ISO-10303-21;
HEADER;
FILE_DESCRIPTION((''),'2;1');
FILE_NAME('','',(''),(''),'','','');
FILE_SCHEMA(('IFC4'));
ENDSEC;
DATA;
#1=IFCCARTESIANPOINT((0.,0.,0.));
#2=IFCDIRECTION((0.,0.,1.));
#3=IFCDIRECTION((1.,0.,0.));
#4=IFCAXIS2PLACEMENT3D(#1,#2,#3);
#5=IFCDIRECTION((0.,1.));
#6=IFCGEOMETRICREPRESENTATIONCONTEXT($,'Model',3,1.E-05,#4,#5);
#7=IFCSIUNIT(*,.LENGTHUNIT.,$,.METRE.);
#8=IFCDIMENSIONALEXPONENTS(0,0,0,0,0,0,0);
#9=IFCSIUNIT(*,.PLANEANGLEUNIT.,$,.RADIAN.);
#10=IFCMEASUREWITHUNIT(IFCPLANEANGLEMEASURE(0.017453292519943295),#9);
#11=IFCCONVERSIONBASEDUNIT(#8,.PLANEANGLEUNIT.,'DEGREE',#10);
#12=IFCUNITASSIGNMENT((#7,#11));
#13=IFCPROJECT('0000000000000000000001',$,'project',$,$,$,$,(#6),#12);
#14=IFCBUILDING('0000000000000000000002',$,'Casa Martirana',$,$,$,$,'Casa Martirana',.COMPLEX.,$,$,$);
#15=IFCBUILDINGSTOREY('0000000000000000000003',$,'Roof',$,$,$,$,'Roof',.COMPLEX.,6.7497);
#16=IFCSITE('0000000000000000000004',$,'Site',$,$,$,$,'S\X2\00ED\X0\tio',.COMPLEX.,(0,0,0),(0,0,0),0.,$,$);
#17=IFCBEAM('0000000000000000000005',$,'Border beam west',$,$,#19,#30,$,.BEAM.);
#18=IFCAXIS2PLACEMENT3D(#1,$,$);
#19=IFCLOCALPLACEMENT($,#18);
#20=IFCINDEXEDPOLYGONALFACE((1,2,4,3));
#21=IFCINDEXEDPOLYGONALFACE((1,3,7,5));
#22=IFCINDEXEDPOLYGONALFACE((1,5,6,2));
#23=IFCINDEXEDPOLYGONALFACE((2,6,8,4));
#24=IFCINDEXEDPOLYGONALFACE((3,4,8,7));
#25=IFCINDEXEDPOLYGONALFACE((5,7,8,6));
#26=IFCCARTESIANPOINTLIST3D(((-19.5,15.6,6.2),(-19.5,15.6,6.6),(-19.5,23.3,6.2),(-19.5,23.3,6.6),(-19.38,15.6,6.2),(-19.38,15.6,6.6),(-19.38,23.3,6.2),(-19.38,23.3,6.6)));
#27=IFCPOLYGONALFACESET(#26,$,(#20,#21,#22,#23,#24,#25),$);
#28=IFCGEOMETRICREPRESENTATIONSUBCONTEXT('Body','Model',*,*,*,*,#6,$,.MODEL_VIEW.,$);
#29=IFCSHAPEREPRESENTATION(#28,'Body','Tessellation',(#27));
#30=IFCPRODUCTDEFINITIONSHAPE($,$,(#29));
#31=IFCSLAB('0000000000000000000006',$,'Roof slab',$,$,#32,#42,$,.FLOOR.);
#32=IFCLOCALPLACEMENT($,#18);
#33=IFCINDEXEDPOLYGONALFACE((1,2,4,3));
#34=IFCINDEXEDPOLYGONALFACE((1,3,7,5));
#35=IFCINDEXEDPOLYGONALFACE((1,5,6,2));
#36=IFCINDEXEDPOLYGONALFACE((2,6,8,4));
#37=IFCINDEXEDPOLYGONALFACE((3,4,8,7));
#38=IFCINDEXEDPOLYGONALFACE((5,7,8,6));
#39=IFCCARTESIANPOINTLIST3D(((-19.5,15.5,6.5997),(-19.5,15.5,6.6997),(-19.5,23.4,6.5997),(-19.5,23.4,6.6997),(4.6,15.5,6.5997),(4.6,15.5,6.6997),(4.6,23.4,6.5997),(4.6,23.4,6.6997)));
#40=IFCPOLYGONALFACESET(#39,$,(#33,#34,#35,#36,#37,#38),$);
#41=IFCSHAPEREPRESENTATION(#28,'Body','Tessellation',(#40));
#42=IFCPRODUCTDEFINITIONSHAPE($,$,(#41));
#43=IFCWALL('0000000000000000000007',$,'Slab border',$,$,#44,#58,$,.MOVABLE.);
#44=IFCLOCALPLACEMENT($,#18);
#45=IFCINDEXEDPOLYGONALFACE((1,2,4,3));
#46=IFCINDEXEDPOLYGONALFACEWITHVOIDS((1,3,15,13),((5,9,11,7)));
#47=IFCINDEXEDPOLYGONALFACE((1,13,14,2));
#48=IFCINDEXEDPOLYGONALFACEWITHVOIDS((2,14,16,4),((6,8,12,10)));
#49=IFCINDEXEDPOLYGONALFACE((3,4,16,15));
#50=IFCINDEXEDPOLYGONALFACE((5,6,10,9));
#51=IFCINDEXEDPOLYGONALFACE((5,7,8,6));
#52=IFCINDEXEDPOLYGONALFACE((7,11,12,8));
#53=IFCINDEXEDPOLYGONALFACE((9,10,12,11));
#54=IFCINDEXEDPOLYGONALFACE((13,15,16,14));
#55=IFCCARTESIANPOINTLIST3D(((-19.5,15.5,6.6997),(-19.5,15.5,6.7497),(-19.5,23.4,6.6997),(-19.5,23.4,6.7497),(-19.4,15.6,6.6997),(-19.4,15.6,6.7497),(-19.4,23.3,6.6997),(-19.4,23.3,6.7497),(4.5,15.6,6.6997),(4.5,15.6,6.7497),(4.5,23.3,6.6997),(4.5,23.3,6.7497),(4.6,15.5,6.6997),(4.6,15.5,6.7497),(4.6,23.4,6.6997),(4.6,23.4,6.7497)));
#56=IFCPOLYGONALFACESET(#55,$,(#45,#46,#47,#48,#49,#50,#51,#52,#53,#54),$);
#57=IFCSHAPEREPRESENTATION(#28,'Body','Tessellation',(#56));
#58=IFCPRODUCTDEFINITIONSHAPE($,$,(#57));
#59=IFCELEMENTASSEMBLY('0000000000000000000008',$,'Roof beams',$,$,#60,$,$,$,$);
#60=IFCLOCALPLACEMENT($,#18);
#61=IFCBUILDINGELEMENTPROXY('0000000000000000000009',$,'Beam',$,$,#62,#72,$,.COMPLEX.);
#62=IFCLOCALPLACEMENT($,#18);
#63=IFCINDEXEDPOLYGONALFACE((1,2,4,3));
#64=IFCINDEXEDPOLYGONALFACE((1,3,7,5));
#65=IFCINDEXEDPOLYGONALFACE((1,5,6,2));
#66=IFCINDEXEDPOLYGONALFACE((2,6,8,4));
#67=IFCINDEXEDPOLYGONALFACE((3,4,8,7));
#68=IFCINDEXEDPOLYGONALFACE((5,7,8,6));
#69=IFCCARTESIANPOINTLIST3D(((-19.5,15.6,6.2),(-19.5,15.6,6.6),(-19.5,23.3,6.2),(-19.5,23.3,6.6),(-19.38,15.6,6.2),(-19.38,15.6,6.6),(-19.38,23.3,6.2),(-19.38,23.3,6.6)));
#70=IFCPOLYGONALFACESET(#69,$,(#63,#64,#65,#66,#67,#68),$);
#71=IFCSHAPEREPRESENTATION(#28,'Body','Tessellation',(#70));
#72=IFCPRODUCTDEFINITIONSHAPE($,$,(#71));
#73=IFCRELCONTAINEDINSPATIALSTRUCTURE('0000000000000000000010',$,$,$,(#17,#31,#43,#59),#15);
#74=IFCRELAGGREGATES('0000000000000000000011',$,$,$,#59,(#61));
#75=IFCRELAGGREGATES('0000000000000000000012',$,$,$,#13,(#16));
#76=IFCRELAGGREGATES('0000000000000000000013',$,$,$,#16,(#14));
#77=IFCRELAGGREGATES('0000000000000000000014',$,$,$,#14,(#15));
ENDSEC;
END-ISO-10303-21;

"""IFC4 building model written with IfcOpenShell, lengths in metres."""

from ifc_helpers import new_model, entity, si_unit, converted_unit, direction, frame, origin_with_axes, origin_2d_with_axis, place, context, subcontext, project, spatial, polyline, rectangle, outline, extrude, source, transform, mapped, element, aggregate, save


model = new_model("IFC4")

# Units and contexts
model_context = context("Model", 3, precision=1e-05, world=origin_with_axes(), true_north=direction((0.0, 1.0)))
body_context = subcontext(model_context, "Body", "Model", "MODEL_VIEW")
ifc_project = project(units=[si_unit("LENGTHUNIT", "METRE"), converted_unit("PLANEANGLEUNIT", "DEGREE", entity("IfcPlaneAngleMeasure", 0.017453292519943295), si_unit("PLANEANGLEUNIT", "RADIAN"), dimensions=[0, 0, 0, 0, 0, 0, 0])], contexts=[model_context])

# Site, building, storey
site = spatial("IfcSite", under=ifc_project, Name="Site", LongName="Sítio", CompositionType="COMPLEX", RefLatitude=(0, 0, 0), RefLongitude=(0, 0, 0), RefElevation=0.0)
building = spatial("IfcBuilding", under=site, Name="Casa Martirana", LongName="Casa Martirana", CompositionType="COMPLEX")
storey = spatial("IfcBuildingStorey", under=building, Name="Roof", LongName="Roof", CompositionType="COMPLEX", Elevation=6.7497)

# Beam
shared_shape = source(origin_with_axes(), body_context, "Body", "SweptSolid", [
    extrude(rectangle(XDim=0.12, YDim=0.4, at=origin_2d_with_axis()), frame((-19.44, 15.6, 6.4), z_axis=(0.0, -1.0, 0.0), x_axis=(1.0, 0.0, 0.0)), (0.0, 0.0, -1.0), 7.7),
])
placement = place(None, origin_with_axes())
element("IfcBeam", 1, at=placement, inside=storey, Name="Border beam west", PredefinedType="BEAM", context=body_context, shape_type="MappedRepresentation", body=[
    mapped(shared_shape, transform((0.0, 0.0, 0.0), x_axis=(1.0, 0.0, 0.0), y_axis=(0.0, 1.0, 0.0), z_axis=(0.0, 0.0, 1.0), scale=1.0)),
])

# Slab
element("IfcSlab", 2, at=placement, inside=storey, Name="Roof slab", PredefinedType="FLOOR", context=body_context, shape_type="SweptSolid", body=[
    extrude(rectangle(XDim=24.1, YDim=7.9, at=origin_2d_with_axis()), frame((-7.45, 19.45, 6.6997), z_axis=(0.0, 0.0, 1.0), x_axis=(1.0, 0.0, 0.0)), (0.0, 0.0, -1.0), 0.1),
])

# Wall
element("IfcWall", 3, at=placement, inside=storey, Name="Slab border", PredefinedType="MOVABLE", context=body_context, shape_type="SweptSolid", body=[
    extrude(outline(polyline([(-12.05, -3.95), (12.05, -3.95), (12.05, 3.95), (-12.05, 3.95), (-12.05, -3.95)]), holes=[polyline([(11.95, 3.85), (-11.95, 3.85), (-11.95, -3.85), (11.95, -3.85), (11.95, 3.85)])]), frame((-7.45, 19.45, 6.6997), z_axis=(0.0, 0.0, 1.0), x_axis=(1.0, 0.0, 0.0)), (0.0, 0.0, 1.0), 0.05),
])

# Element assembly, building element proxy
assembly = element("IfcElementAssembly", 4, inside=storey, Name="Roof beams")
proxy_1 = element("IfcBuildingElementProxy", 5, at=placement, Name="Beam", PredefinedType="COMPLEX", context=body_context, shape_type="MappedRepresentation", body=[
    mapped(shared_shape, transform((0.0, 0.0, 0.0), x_axis=(1.0, 0.0, 0.0), y_axis=(0.0, 1.0, 0.0), z_axis=(0.0, 0.0, 1.0), scale=1.0)),
])
aggregate(assembly, [proxy_1])

save(model, "model.ifc")
